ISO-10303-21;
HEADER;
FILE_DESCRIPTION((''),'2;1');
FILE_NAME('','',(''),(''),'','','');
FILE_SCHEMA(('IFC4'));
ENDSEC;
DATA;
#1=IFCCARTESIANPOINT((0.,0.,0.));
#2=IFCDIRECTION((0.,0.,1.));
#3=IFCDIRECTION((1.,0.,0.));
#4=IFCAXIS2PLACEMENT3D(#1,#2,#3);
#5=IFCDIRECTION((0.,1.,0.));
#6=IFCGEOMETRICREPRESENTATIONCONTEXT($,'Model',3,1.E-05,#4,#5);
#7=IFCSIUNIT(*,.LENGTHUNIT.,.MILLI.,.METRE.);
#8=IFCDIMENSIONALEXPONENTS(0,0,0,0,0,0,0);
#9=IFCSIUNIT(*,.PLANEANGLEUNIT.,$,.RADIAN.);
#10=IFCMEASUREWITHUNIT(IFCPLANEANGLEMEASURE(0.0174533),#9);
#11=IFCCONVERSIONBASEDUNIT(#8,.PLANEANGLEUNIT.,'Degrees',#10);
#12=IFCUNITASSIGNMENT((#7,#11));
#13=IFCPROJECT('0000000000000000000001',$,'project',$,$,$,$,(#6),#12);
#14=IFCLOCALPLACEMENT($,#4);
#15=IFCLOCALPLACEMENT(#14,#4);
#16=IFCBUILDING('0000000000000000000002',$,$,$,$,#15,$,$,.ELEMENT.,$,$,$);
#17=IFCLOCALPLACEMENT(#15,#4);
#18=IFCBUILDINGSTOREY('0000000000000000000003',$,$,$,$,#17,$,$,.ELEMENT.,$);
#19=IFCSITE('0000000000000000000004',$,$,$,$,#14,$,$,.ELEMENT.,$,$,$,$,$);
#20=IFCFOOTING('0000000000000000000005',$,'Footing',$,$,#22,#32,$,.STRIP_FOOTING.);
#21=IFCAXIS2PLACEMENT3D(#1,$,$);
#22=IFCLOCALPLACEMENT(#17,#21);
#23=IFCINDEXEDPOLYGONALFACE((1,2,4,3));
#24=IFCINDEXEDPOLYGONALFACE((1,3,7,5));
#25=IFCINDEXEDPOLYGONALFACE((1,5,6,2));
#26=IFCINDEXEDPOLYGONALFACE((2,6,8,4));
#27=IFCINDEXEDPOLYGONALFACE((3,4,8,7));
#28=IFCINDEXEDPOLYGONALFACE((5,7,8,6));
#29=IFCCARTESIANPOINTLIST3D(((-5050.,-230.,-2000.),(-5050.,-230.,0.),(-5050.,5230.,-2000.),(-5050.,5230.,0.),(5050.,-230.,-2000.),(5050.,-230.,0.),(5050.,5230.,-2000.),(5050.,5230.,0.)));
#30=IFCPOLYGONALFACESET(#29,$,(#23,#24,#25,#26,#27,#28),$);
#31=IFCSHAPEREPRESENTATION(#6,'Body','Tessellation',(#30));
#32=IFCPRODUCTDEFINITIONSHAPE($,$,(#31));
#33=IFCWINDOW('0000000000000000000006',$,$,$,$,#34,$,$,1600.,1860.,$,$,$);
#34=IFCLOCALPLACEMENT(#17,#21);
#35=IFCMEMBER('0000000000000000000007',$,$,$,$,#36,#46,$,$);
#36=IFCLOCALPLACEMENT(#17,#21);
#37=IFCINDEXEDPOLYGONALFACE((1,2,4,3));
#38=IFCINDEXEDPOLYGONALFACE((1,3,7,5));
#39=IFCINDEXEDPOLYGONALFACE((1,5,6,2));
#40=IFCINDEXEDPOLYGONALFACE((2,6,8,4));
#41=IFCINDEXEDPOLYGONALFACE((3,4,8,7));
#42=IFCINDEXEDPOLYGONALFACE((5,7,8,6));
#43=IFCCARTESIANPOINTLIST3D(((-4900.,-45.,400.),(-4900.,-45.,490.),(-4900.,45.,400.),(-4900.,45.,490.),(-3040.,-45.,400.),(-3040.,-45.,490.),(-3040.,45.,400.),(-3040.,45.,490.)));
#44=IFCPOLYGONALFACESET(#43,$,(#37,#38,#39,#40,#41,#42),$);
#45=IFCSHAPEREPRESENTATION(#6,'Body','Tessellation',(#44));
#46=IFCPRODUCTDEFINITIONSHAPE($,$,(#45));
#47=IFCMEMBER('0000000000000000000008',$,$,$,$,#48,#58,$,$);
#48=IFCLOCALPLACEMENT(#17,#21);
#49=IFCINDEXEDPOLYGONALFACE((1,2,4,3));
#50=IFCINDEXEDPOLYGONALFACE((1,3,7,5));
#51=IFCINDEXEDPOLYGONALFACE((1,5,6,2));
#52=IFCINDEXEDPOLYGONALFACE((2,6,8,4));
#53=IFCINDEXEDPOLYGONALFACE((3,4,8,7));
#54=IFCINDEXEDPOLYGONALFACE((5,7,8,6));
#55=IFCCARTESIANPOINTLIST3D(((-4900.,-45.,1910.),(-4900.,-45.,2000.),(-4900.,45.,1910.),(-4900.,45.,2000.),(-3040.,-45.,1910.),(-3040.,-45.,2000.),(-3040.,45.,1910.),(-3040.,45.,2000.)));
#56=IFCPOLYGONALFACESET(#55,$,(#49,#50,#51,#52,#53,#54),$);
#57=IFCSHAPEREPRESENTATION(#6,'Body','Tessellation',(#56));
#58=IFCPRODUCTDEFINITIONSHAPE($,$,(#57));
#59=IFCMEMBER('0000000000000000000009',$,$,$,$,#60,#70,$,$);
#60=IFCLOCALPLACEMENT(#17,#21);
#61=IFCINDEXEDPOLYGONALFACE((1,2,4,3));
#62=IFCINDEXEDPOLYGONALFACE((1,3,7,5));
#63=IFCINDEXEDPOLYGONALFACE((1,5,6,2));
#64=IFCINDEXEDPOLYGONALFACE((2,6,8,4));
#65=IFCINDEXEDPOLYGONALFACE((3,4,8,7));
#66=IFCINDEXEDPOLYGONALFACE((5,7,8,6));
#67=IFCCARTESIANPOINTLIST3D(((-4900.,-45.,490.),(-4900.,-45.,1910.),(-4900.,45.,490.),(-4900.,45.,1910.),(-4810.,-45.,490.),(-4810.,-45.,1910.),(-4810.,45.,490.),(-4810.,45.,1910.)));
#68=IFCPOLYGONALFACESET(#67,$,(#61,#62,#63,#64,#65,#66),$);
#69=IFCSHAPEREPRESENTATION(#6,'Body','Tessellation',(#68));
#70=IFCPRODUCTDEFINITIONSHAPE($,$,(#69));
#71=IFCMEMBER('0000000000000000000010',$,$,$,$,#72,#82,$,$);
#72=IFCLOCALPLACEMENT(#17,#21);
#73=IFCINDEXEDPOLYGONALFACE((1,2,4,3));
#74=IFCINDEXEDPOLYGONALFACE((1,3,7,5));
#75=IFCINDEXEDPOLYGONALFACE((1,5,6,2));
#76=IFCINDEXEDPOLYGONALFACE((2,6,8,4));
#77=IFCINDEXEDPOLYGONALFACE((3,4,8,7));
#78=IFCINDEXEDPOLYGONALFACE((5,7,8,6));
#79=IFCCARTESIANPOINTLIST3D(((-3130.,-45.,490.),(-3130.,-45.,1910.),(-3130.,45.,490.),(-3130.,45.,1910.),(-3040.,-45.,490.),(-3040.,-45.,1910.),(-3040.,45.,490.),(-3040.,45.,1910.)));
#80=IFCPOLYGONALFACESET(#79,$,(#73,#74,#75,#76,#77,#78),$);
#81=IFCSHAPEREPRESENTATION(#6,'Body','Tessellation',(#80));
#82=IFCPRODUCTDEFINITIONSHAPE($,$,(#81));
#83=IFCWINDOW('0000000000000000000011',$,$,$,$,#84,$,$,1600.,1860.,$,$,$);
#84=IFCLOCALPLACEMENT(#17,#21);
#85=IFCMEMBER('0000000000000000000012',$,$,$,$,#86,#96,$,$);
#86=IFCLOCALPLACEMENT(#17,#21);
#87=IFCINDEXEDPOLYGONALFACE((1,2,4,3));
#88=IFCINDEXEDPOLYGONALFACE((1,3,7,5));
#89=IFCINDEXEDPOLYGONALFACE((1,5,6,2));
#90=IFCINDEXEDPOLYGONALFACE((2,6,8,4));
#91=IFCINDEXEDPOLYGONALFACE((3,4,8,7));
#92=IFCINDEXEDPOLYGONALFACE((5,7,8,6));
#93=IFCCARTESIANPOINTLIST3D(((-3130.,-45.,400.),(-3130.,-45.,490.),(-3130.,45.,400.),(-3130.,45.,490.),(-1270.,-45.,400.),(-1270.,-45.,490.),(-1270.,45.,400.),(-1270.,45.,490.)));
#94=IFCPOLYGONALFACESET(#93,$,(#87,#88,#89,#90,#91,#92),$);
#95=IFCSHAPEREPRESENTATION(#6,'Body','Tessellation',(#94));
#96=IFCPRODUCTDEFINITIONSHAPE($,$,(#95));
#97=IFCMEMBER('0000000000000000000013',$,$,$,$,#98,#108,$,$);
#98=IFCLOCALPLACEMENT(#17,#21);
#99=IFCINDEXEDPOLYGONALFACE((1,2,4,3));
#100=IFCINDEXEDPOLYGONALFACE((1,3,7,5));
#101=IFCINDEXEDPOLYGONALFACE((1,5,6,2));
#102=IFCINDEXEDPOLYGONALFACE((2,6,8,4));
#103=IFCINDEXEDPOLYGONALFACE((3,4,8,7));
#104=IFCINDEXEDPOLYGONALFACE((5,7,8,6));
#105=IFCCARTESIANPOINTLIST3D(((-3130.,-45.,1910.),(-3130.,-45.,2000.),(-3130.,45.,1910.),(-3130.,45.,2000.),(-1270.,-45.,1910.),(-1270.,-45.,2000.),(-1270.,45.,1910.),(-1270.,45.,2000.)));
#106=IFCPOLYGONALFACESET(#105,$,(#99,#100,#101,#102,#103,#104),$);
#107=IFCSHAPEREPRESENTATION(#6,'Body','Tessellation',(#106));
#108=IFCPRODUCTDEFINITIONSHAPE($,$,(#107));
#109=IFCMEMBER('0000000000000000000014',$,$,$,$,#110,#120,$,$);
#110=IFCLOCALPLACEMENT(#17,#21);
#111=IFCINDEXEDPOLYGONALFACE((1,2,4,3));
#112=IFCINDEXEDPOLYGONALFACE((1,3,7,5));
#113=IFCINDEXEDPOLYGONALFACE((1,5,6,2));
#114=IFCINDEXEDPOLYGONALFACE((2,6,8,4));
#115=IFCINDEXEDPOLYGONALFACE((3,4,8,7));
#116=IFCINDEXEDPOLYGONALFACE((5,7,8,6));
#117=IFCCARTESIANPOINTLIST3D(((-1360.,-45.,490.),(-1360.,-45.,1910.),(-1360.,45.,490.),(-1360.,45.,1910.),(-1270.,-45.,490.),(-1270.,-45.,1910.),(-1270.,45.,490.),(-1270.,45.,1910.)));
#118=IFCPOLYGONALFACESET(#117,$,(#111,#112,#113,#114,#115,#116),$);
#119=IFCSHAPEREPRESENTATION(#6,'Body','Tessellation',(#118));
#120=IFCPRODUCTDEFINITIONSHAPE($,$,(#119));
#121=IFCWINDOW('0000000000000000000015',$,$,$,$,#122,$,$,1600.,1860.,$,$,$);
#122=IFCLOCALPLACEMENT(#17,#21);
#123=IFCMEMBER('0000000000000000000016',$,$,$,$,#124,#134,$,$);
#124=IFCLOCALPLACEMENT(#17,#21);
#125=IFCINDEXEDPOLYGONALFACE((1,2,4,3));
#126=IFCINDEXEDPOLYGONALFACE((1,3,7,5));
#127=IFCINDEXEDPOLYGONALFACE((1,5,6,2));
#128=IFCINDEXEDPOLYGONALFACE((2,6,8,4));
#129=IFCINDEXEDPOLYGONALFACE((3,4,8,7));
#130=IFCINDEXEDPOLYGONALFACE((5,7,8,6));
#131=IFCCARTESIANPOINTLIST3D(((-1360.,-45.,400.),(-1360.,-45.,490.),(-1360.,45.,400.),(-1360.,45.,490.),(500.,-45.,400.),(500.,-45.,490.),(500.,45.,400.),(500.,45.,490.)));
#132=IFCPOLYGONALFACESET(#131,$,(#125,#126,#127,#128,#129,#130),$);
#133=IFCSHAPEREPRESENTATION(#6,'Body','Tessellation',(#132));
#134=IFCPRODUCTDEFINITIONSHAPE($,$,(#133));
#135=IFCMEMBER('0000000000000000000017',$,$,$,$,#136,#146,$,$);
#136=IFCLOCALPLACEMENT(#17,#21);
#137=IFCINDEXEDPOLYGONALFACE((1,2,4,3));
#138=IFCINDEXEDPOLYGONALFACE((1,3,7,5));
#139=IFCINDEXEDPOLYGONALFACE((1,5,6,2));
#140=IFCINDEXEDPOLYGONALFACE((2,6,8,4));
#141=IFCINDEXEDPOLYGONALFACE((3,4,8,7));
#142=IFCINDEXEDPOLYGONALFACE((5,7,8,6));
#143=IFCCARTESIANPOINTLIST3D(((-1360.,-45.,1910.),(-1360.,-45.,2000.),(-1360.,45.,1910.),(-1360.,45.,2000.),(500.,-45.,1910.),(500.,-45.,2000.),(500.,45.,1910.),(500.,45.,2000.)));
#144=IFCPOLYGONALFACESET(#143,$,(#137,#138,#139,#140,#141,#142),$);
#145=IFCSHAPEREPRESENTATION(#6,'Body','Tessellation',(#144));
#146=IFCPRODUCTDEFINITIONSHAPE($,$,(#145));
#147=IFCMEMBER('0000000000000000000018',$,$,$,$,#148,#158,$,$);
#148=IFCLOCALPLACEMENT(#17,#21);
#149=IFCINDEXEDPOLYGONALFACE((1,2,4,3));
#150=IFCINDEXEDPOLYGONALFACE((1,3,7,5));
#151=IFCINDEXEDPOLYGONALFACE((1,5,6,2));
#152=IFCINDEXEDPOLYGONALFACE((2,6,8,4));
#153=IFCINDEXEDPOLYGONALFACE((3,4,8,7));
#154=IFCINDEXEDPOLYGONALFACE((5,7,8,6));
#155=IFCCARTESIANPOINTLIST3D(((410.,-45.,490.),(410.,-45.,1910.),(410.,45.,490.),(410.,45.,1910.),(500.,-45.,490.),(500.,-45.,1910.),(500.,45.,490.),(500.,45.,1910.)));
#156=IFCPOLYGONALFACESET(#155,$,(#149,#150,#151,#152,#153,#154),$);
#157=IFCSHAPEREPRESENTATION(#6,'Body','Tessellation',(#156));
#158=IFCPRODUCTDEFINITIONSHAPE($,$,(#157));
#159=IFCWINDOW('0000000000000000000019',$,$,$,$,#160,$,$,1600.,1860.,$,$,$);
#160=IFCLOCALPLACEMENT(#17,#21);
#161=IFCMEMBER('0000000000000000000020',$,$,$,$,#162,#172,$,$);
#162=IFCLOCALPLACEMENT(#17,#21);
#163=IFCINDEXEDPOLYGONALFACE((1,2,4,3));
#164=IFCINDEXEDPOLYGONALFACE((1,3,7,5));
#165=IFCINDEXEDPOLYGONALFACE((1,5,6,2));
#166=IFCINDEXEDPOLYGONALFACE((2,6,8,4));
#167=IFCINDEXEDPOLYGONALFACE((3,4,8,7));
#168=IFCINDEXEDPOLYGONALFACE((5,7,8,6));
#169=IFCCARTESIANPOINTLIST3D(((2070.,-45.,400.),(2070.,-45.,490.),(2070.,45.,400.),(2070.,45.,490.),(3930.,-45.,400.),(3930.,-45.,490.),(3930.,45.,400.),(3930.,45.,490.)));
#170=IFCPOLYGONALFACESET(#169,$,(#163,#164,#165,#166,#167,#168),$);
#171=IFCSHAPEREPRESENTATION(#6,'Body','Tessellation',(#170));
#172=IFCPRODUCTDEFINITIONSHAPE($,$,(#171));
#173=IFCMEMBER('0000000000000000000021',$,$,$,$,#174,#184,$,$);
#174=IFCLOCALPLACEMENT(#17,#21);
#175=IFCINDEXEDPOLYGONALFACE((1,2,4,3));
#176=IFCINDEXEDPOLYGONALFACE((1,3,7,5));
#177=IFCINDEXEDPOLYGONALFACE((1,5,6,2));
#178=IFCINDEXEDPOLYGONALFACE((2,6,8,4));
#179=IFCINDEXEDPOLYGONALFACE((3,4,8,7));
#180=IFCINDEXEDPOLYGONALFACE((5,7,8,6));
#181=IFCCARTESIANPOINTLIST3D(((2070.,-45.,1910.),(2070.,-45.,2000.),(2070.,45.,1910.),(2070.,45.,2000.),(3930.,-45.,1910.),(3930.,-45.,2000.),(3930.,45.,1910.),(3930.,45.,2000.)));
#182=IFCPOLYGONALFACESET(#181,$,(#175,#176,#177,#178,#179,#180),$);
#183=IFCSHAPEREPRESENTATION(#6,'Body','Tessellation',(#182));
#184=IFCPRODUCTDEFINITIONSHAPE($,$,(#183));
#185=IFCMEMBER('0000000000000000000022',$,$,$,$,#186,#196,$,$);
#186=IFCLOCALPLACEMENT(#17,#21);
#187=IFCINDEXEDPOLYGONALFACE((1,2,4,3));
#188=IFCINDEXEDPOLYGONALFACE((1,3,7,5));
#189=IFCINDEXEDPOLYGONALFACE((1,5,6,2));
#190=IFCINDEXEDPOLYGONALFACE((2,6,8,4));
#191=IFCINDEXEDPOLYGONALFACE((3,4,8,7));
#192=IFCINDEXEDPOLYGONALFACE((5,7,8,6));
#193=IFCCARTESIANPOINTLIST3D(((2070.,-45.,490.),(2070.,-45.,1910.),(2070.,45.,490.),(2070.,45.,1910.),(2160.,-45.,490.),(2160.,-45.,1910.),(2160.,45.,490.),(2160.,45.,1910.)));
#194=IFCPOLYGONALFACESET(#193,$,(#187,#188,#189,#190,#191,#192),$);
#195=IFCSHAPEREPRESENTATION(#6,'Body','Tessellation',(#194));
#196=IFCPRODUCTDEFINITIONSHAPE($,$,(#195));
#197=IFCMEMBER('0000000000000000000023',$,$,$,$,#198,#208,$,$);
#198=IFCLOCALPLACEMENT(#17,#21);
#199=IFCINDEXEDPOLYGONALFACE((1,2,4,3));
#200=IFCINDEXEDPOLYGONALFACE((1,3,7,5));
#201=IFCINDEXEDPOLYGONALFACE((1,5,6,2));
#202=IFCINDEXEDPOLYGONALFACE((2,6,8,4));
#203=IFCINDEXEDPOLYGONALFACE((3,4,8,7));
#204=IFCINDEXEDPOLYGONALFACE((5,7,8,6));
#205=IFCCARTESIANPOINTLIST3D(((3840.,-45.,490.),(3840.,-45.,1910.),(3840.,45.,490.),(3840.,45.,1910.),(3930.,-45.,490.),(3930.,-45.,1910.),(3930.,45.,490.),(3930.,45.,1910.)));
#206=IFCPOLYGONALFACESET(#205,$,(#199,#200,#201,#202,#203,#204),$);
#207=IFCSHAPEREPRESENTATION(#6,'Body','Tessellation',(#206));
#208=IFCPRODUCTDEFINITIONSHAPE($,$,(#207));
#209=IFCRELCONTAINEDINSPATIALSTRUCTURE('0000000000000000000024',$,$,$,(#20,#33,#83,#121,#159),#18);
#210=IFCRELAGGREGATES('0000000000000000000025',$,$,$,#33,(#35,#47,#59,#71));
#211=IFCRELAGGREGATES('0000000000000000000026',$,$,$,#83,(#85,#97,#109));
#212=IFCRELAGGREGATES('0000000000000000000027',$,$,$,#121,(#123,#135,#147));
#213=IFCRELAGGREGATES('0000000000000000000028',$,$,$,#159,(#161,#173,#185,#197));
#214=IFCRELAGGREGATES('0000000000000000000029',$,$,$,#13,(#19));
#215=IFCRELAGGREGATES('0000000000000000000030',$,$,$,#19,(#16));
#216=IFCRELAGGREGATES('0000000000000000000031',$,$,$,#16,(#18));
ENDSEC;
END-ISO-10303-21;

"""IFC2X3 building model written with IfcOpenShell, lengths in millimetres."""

from ifc_helpers import new_model, entity, si_unit, converted_unit, direction, frame, origin_with_axes, place, context, project, spatial, polyline, outline, extrude, element, aggregate, save


model = new_model("IFC2X3")

# Units and contexts
model_context = context("Model", 3, precision=1e-05, world=origin_with_axes(), true_north=direction((0.0, 1.0, 0.0)))
ifc_project = project(units=[si_unit("LENGTHUNIT", "METRE", prefix="MILLI"), converted_unit("PLANEANGLEUNIT", "Degrees", entity("IfcPlaneAngleMeasure", 0.0174533), si_unit("PLANEANGLEUNIT", "RADIAN"), dimensions=[0, 0, 0, 0, 0, 0, 0])], contexts=[model_context])

# Site, building, storey
site_placement = place(None, origin_with_axes())
site = spatial("IfcSite", under=ifc_project, at=site_placement, CompositionType="ELEMENT")
building_placement = place(site_placement, origin_with_axes())
building = spatial("IfcBuilding", under=site, at=building_placement, CompositionType="ELEMENT")
storey_placement = place(building_placement, origin_with_axes())
storey = spatial("IfcBuildingStorey", under=building, at=storey_placement, CompositionType="ELEMENT")

# Footing
footing_placement = place(None, frame((0.0, 2500.0, -2000.0), z_axis=(0.0, 0.0, 1.0), x_axis=(1.0, 0.0, 0.0)))
element("IfcFooting", 1, at=footing_placement, inside=storey, Name="Footing", PredefinedType="STRIP_FOOTING", context=model_context, shape_type="SweptSolid", body=[
    extrude(outline(polyline([(-5050.0, -2730.0), (5050.0, -2730.0), (5050.0, 2730.0), (-5050.0, 2730.0), (-5050.0, -2730.0), (-5050.0, -2730.0)])), origin_with_axes(), (0.0, 0.0, 1.0), 2000.0),
])

# Windows, members
window_1_placement = place(storey_placement, frame((-4900.0, -45.0, 400.0), z_axis=(0.0, 0.0, 1.0), x_axis=(1.0, 0.0, 0.0)))
window_1 = element("IfcWindow", 2, at=window_1_placement, inside=storey, OverallHeight=1600.0, OverallWidth=1860.0)
member_1_placement = place(window_1_placement, frame((930.0, 45.0, 0.0), z_axis=(0.0, 0.0, 1.0), x_axis=(1.0, 0.0, 0.0)))
member_1 = element("IfcMember", 3, at=member_1_placement, context=model_context, shape_type="SweptSolid", body=[
    extrude(outline(polyline([(-930.0, -45.0), (930.0, -45.0), (930.0, 45.0), (-930.0, 45.0), (-930.0, -45.0), (-930.0, -45.0)])), origin_with_axes(), (0.0, 0.0, 1.0), 90.0),
])
member_2_placement = place(window_1_placement, frame((930.0, 45.0, 1510.0), z_axis=(0.0, 0.0, 1.0), x_axis=(1.0, 0.0, 0.0)))
member_2 = element("IfcMember", 4, at=member_2_placement, context=model_context, shape_type="SweptSolid", body=[
    extrude(outline(polyline([(-930.0, -45.0), (930.0, -45.0), (930.0, 45.0), (-930.0, 45.0), (-930.0, -45.0), (-930.0, -45.0)])), origin_with_axes(), (0.0, 0.0, 1.0), 90.0),
])
member_3_placement = place(window_1_placement, frame((45.0, 45.0, 90.0), z_axis=(0.0, 0.0, 1.0), x_axis=(1.0, 0.0, 0.0)))
member_3 = element("IfcMember", 5, at=member_3_placement, context=model_context, shape_type="SweptSolid", body=[
    extrude(outline(polyline([(-45.0, -45.0), (45.0, -45.0), (45.0, 45.0), (-45.0, 45.0), (-45.0, -45.0), (-45.0, -45.0)])), origin_with_axes(), (0.0, 0.0, 1.0), 1420.0),
])
member_4_placement = place(window_1_placement, frame((1815.0, 45.0, 90.0), z_axis=(0.0, 0.0, 1.0), x_axis=(1.0, 0.0, 0.0)))
member_4 = element("IfcMember", 6, at=member_4_placement, context=model_context, shape_type="SweptSolid", body=[
    extrude(outline(polyline([(-45.0, -45.0), (45.0, -45.0), (45.0, 45.0), (-45.0, 45.0), (-45.0, -45.0), (-45.0, -45.0)])), origin_with_axes(), (0.0, 0.0, 1.0), 1420.0),
])
window_2_placement = place(storey_placement, frame((-3130.0, -45.0, 400.0), z_axis=(0.0, 0.0, 1.0), x_axis=(1.0, 0.0, 0.0)))
window_2 = element("IfcWindow", 7, at=window_2_placement, inside=storey, OverallHeight=1600.0, OverallWidth=1860.0)
member_5_placement = place(window_2_placement, frame((930.0, 45.0, 0.0), z_axis=(0.0, 0.0, 1.0), x_axis=(1.0, 0.0, 0.0)))
member_5 = element("IfcMember", 8, at=member_5_placement, context=model_context, shape_type="SweptSolid", body=[
    extrude(outline(polyline([(-930.0, -45.0), (930.0, -45.0), (930.0, 45.0), (-930.0, 45.0), (-930.0, -45.0), (-930.0, -45.0)])), origin_with_axes(), (0.0, 0.0, 1.0), 90.0),
])
member_6_placement = place(window_2_placement, frame((930.0, 45.0, 1510.0), z_axis=(0.0, 0.0, 1.0), x_axis=(1.0, 0.0, 0.0)))
member_6 = element("IfcMember", 9, at=member_6_placement, context=model_context, shape_type="SweptSolid", body=[
    extrude(outline(polyline([(-930.0, -45.0), (930.0, -45.0), (930.0, 45.0), (-930.0, 45.0), (-930.0, -45.0), (-930.0, -45.0)])), origin_with_axes(), (0.0, 0.0, 1.0), 90.0),
])
member_7_placement = place(window_2_placement, frame((1815.0, 45.0, 90.0), z_axis=(0.0, 0.0, 1.0), x_axis=(1.0, 0.0, 0.0)))
member_7 = element("IfcMember", 10, at=member_7_placement, context=model_context, shape_type="SweptSolid", body=[
    extrude(outline(polyline([(-45.0, -45.0), (45.0, -45.0), (45.0, 45.0), (-45.0, 45.0), (-45.0, -45.0), (-45.0, -45.0)])), origin_with_axes(), (0.0, 0.0, 1.0), 1420.0),
])
window_3_placement = place(storey_placement, frame((-1360.0, -45.0, 400.0), z_axis=(0.0, 0.0, 1.0), x_axis=(1.0, 0.0, 0.0)))
window_3 = element("IfcWindow", 11, at=window_3_placement, inside=storey, OverallHeight=1600.0, OverallWidth=1860.0)
member_8_placement = place(window_3_placement, frame((930.0, 45.0, 0.0), z_axis=(0.0, 0.0, 1.0), x_axis=(1.0, 0.0, 0.0)))
member_8 = element("IfcMember", 12, at=member_8_placement, context=model_context, shape_type="SweptSolid", body=[
    extrude(outline(polyline([(-930.0, -45.0), (930.0, -45.0), (930.0, 45.0), (-930.0, 45.0), (-930.0, -45.0), (-930.0, -45.0)])), origin_with_axes(), (0.0, 0.0, 1.0), 90.0),
])
member_9_placement = place(window_3_placement, frame((930.0, 45.0, 1510.0), z_axis=(0.0, 0.0, 1.0), x_axis=(1.0, 0.0, 0.0)))
member_9 = element("IfcMember", 13, at=member_9_placement, context=model_context, shape_type="SweptSolid", body=[
    extrude(outline(polyline([(-930.0, -45.0), (930.0, -45.0), (930.0, 45.0), (-930.0, 45.0), (-930.0, -45.0), (-930.0, -45.0)])), origin_with_axes(), (0.0, 0.0, 1.0), 90.0),
])
member_10_placement = place(window_3_placement, frame((1815.0, 45.0, 90.0), z_axis=(0.0, 0.0, 1.0), x_axis=(1.0, 0.0, 0.0)))
member_10 = element("IfcMember", 14, at=member_10_placement, context=model_context, shape_type="SweptSolid", body=[
    extrude(outline(polyline([(-45.0, -45.0), (45.0, -45.0), (45.0, 45.0), (-45.0, 45.0), (-45.0, -45.0), (-45.0, -45.0)])), origin_with_axes(), (0.0, 0.0, 1.0), 1420.0),
])
window_4_placement = place(storey_placement, frame((2070.0, -45.0, 400.0), z_axis=(0.0, 0.0, 1.0), x_axis=(1.0, 0.0, 0.0)))
window_4 = element("IfcWindow", 15, at=window_4_placement, inside=storey, OverallHeight=1600.0, OverallWidth=1860.0)
member_11_placement = place(window_4_placement, frame((930.0, 45.0, 0.0), z_axis=(0.0, 0.0, 1.0), x_axis=(1.0, 0.0, 0.0)))
member_11 = element("IfcMember", 16, at=member_11_placement, context=model_context, shape_type="SweptSolid", body=[
    extrude(outline(polyline([(-930.0, -45.0), (930.0, -45.0), (930.0, 45.0), (-930.0, 45.0), (-930.0, -45.0), (-930.0, -45.0)])), origin_with_axes(), (0.0, 0.0, 1.0), 90.0),
])
member_12_placement = place(window_4_placement, frame((930.0, 45.0, 1510.0), z_axis=(0.0, 0.0, 1.0), x_axis=(1.0, 0.0, 0.0)))
member_12 = element("IfcMember", 17, at=member_12_placement, context=model_context, shape_type="SweptSolid", body=[
    extrude(outline(polyline([(-930.0, -45.0), (930.0, -45.0), (930.0, 45.0), (-930.0, 45.0), (-930.0, -45.0), (-930.0, -45.0)])), origin_with_axes(), (0.0, 0.0, 1.0), 90.0),
])
member_13_placement = place(window_4_placement, frame((45.0, 45.0, 90.0), z_axis=(0.0, 0.0, 1.0), x_axis=(1.0, 0.0, 0.0)))
member_13 = element("IfcMember", 18, at=member_13_placement, context=model_context, shape_type="SweptSolid", body=[
    extrude(outline(polyline([(-45.0, -45.0), (45.0, -45.0), (45.0, 45.0), (-45.0, 45.0), (-45.0, -45.0), (-45.0, -45.0)])), origin_with_axes(), (0.0, 0.0, 1.0), 1420.0),
])
member_14_placement = place(window_4_placement, frame((1815.0, 45.0, 90.0), z_axis=(0.0, 0.0, 1.0), x_axis=(1.0, 0.0, 0.0)))
member_14 = element("IfcMember", 19, at=member_14_placement, context=model_context, shape_type="SweptSolid", body=[
    extrude(outline(polyline([(-45.0, -45.0), (45.0, -45.0), (45.0, 45.0), (-45.0, 45.0), (-45.0, -45.0), (-45.0, -45.0)])), origin_with_axes(), (0.0, 0.0, 1.0), 1420.0),
])

aggregate(window_1, [member_1, member_2, member_3, member_4])
aggregate(window_2, [member_5, member_6, member_7])
aggregate(window_3, [member_8, member_9, member_10])
aggregate(window_4, [member_11, member_12, member_13, member_14])

save(model, "model.ifc")
